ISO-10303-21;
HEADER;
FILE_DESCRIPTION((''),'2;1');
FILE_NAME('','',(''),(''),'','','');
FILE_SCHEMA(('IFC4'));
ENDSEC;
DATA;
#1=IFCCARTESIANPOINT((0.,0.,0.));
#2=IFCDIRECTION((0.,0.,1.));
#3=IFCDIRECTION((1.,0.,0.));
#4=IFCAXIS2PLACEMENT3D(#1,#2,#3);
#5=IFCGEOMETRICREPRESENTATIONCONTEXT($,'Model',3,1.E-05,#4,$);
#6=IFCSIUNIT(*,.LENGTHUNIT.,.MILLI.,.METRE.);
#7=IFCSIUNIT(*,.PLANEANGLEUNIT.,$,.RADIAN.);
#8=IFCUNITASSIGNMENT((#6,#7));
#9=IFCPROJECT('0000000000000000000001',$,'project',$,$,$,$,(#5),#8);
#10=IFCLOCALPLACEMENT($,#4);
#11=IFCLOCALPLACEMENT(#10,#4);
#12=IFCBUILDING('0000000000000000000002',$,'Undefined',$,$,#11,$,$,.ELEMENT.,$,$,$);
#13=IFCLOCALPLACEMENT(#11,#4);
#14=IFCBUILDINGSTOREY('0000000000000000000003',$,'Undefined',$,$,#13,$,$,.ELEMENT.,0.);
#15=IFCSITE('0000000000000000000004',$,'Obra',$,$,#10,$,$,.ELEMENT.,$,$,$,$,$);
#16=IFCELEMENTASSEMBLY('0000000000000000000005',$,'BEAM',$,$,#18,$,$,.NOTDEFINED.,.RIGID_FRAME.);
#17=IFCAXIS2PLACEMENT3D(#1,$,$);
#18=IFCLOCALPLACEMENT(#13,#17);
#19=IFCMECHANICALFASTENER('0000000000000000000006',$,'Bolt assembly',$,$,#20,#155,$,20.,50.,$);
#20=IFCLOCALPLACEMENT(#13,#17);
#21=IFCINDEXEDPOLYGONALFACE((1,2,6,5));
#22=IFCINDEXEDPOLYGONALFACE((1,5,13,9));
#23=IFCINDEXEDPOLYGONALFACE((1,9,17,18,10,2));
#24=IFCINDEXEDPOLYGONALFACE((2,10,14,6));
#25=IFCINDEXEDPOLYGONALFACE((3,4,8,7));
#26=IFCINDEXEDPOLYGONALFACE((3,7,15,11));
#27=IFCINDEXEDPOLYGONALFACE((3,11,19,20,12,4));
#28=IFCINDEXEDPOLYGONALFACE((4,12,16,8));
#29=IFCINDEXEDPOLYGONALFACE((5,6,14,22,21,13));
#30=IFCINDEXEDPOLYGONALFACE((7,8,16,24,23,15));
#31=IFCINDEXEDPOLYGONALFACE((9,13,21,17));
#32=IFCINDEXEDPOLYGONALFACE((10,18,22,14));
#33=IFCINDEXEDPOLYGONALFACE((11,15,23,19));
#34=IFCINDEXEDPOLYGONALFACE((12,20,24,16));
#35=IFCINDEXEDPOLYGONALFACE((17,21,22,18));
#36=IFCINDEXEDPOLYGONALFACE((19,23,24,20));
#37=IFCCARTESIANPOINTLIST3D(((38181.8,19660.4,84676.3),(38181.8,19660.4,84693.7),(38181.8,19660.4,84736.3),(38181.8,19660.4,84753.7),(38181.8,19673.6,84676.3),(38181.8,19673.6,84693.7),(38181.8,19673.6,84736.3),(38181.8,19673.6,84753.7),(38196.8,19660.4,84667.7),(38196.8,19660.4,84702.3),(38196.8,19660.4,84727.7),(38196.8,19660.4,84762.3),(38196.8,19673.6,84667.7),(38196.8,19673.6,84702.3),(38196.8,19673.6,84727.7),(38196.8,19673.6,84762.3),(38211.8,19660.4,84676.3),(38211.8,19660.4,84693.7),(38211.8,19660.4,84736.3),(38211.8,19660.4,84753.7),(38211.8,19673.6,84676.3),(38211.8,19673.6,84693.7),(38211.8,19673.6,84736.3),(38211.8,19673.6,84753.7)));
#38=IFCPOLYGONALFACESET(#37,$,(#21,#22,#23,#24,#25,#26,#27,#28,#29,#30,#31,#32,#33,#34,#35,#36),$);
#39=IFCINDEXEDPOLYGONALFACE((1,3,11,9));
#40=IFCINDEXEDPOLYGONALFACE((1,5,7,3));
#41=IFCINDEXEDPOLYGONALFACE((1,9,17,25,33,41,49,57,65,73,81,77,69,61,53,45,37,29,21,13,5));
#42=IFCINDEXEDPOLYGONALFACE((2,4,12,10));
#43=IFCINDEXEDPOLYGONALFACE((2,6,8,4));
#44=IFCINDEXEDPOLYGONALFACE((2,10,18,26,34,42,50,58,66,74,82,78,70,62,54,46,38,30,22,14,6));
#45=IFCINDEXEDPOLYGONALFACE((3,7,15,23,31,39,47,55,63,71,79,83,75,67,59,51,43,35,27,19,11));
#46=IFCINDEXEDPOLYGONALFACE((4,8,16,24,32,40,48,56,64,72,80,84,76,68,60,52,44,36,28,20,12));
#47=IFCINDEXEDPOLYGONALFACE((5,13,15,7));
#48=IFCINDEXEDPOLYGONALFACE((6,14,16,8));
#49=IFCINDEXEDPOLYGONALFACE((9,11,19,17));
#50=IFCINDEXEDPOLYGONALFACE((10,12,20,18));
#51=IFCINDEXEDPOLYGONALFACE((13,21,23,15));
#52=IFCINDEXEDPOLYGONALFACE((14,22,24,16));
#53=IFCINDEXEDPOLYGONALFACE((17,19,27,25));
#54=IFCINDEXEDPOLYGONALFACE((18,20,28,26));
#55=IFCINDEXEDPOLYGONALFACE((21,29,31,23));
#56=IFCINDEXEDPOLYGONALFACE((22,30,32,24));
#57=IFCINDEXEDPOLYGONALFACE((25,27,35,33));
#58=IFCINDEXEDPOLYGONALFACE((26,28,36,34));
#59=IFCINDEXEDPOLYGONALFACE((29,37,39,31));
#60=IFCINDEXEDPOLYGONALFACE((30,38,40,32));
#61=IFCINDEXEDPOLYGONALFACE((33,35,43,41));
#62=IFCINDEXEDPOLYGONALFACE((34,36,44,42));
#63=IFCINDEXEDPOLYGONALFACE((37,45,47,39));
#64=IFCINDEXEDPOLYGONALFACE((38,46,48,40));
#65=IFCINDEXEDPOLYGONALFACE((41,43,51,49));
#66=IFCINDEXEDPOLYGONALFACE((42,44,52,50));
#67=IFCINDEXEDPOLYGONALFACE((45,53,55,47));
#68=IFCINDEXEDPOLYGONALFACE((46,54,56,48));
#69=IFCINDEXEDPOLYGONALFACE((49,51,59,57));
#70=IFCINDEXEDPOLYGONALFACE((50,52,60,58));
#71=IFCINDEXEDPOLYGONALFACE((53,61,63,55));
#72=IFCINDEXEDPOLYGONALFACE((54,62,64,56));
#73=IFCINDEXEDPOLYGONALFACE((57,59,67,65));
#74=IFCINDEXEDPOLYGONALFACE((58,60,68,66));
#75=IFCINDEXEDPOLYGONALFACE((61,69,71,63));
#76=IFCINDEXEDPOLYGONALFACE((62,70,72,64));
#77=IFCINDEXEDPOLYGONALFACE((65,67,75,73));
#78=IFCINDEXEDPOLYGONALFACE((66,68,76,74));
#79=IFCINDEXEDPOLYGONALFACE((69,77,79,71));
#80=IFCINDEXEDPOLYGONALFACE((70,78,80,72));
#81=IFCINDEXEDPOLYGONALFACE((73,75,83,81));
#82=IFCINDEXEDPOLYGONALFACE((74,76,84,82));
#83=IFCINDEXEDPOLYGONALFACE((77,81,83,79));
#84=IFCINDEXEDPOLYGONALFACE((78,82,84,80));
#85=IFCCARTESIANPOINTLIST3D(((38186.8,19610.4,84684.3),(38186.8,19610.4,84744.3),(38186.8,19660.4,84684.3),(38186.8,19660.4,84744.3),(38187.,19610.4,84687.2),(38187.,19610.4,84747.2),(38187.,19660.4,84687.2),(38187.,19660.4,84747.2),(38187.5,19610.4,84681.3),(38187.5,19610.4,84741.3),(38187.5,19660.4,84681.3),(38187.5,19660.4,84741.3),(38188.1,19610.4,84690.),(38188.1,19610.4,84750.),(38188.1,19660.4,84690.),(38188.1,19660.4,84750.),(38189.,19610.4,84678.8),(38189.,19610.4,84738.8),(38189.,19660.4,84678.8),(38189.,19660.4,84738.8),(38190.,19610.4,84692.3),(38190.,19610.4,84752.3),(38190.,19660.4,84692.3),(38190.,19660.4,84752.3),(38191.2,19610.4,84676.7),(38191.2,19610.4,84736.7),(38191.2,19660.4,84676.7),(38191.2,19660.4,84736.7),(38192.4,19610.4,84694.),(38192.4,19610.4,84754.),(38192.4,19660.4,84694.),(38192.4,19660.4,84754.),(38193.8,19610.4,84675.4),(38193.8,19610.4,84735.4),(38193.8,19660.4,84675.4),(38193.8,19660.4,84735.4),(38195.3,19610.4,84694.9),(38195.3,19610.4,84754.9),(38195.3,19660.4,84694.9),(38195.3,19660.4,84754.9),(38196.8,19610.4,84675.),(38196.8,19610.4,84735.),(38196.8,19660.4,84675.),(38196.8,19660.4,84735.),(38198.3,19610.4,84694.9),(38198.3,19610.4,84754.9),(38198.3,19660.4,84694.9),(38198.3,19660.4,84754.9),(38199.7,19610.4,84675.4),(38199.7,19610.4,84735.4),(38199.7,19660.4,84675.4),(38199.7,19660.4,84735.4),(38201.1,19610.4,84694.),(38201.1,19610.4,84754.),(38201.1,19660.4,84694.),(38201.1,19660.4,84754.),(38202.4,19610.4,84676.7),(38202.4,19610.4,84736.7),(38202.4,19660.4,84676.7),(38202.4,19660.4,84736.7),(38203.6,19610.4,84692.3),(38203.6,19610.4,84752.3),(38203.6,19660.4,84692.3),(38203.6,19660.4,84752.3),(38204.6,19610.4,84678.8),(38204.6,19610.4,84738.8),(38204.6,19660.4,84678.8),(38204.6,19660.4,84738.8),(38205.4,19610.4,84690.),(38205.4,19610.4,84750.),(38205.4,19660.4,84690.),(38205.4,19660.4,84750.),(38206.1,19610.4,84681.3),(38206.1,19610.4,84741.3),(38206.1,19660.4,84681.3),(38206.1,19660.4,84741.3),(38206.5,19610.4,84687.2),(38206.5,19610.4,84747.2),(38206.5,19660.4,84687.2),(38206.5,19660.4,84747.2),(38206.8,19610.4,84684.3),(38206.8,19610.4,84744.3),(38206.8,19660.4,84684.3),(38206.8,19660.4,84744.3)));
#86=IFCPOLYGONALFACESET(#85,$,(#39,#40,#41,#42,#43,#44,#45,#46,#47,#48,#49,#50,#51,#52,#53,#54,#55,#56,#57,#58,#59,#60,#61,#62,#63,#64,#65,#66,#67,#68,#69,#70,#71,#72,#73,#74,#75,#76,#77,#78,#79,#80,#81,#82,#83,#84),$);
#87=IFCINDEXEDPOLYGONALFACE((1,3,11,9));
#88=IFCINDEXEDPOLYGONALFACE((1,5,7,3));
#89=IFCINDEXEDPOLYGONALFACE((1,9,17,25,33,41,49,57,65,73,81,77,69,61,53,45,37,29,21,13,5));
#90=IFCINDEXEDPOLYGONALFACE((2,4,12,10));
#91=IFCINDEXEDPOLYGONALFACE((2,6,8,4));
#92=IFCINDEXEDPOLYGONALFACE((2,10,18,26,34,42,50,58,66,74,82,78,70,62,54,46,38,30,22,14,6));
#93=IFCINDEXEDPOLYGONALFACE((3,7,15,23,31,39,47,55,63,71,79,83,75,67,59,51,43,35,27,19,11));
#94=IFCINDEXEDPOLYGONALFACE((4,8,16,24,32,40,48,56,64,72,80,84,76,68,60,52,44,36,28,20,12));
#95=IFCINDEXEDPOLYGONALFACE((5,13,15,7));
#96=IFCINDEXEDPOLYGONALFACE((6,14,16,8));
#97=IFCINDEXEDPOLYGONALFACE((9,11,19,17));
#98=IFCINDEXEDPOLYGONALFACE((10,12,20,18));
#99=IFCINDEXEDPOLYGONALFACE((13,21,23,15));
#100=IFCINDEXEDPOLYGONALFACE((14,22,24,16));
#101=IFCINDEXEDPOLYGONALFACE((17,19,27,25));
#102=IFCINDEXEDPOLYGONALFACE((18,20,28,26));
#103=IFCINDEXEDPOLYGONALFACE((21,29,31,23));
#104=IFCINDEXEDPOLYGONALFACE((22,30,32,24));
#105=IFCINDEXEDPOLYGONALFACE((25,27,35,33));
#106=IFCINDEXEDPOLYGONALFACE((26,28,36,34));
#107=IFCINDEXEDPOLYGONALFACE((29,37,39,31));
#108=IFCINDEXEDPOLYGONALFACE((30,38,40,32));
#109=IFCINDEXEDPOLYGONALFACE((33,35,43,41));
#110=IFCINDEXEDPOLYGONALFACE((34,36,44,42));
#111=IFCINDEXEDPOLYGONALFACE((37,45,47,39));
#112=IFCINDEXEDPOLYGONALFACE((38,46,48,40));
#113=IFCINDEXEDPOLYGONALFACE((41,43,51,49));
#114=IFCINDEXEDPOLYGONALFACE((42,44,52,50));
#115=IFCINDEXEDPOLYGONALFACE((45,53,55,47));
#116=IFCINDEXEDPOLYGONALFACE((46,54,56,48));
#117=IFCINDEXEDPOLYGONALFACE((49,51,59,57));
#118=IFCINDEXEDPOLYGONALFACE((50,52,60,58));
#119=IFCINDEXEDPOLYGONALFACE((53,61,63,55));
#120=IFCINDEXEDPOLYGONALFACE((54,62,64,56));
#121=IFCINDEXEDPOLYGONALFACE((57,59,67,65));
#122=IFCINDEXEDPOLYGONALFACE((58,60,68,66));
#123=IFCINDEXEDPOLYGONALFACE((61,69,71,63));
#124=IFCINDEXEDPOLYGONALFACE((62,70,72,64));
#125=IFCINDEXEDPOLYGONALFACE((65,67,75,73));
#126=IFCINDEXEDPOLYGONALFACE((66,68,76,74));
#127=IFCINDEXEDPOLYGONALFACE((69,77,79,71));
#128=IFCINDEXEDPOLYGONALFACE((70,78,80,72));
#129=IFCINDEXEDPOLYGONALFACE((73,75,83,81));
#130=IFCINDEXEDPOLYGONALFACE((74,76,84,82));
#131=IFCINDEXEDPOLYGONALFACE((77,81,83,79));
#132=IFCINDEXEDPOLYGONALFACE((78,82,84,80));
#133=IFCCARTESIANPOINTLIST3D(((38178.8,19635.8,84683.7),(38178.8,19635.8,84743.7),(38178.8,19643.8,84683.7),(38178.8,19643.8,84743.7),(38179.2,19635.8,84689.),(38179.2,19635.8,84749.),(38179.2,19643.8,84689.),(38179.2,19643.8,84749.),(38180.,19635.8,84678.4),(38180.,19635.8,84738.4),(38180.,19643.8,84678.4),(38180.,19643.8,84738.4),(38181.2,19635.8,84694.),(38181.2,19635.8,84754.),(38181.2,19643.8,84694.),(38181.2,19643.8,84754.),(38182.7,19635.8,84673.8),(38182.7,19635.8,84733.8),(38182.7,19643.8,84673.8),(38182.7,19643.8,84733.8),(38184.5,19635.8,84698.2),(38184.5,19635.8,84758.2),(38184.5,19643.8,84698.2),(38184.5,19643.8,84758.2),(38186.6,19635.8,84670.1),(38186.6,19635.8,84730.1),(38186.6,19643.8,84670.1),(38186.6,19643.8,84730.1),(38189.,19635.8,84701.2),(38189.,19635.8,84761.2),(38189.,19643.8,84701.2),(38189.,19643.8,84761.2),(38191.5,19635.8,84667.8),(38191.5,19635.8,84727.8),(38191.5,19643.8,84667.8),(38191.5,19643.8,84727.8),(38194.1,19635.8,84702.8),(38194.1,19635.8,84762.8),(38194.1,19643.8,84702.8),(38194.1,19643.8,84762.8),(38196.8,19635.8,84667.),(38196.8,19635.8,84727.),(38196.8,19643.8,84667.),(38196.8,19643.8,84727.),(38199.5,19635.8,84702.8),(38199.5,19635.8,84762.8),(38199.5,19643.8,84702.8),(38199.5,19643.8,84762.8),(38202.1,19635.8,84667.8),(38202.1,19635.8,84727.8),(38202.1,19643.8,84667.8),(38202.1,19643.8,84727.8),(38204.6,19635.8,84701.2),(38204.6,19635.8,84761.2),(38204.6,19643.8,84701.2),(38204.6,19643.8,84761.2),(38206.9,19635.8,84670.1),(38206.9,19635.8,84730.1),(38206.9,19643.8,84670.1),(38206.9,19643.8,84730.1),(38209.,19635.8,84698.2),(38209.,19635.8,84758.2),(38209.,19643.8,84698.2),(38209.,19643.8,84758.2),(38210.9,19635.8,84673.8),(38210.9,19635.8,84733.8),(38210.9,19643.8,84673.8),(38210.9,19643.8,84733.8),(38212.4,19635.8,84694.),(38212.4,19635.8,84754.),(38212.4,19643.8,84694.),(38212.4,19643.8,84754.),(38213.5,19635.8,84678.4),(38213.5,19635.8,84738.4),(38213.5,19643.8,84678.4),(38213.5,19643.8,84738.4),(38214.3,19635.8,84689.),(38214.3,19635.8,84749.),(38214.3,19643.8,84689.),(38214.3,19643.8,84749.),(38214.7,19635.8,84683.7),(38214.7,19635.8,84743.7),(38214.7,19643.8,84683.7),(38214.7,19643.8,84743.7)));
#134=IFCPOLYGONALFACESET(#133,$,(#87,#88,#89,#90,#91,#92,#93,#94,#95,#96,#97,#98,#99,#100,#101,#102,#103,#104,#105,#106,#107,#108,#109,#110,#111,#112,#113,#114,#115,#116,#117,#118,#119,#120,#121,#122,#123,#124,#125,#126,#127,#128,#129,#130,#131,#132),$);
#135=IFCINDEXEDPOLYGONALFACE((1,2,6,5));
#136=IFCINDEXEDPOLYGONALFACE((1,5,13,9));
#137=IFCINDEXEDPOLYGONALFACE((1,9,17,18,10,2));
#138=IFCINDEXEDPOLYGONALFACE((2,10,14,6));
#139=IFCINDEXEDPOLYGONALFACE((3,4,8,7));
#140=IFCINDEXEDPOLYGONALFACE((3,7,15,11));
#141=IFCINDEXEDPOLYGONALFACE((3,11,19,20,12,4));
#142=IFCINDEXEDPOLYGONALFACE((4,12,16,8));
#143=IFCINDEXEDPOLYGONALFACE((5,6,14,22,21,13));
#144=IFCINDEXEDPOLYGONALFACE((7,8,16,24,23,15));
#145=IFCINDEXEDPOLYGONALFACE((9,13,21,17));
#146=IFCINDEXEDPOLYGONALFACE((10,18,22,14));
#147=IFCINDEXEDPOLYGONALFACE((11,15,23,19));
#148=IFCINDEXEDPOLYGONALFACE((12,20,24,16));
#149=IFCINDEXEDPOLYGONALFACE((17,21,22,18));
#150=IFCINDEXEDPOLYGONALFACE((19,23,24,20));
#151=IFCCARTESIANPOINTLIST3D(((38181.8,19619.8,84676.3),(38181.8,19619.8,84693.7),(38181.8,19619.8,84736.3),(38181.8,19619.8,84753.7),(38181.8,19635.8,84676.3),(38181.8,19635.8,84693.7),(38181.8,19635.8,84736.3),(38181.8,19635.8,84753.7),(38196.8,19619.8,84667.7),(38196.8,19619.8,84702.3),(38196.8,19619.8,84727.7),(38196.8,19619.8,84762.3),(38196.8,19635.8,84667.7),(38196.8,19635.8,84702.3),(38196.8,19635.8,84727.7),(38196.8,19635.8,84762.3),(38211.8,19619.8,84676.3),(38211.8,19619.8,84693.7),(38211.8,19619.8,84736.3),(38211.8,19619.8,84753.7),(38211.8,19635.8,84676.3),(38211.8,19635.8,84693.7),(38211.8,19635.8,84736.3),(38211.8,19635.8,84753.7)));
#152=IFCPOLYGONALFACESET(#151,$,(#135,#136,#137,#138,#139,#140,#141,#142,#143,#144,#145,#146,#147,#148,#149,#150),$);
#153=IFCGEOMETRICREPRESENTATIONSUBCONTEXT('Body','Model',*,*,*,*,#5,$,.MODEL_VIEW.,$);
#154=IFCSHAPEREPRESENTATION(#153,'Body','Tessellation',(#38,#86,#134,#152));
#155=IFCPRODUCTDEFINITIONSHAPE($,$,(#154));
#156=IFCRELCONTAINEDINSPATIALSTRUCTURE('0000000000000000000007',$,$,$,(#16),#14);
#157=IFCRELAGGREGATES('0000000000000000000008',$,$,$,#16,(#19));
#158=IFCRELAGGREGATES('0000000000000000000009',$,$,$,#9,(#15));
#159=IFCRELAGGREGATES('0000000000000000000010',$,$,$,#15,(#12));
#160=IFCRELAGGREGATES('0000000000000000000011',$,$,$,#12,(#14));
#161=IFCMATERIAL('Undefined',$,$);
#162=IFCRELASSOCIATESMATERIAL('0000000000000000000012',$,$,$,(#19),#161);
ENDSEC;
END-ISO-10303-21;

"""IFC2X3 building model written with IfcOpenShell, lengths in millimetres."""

from ifc_helpers import new_model, si_unit, frame, origin_with_axes, origin_2d_with_axis, place, context, subcontext, project, spatial, polyline, circle, outline, extrude, source, transform, mapped, material, element, aggregate, save


model = new_model("IFC2X3")

# Units and contexts
model_context = context("Model", 3, precision=1e-05, world=origin_with_axes())
body_context = subcontext(model_context, "Body", "Model", "MODEL_VIEW")
ifc_project = project(units=[si_unit("LENGTHUNIT", "METRE", prefix="MILLI"), si_unit("PLANEANGLEUNIT", "RADIAN")], contexts=[model_context])

# Site, building, storey
site_placement = place(None, origin_with_axes())
site = spatial("IfcSite", under=ifc_project, at=site_placement, Name="Obra", CompositionType="ELEMENT")
building_placement = place(site_placement, origin_with_axes())
building = spatial("IfcBuilding", under=site, at=building_placement, Name="Undefined", CompositionType="ELEMENT")
storey_placement = place(building_placement, origin_with_axes())
storey = spatial("IfcBuildingStorey", under=building, at=storey_placement, Name="Undefined", CompositionType="ELEMENT", Elevation=0.0)

# Shared definitions
ifc_material_1 = material(Name="Undefined")

# Element assembly, mechanical fastener
assembly_1_placement = place(storey_placement, origin_with_axes())
assembly_1 = element("IfcElementAssembly", 1, at=assembly_1_placement, inside=storey, Name="BEAM", AssemblyPlace="NOTDEFINED", PredefinedType="RIGID_FRAME")
shared_shape_1 = source(origin_with_axes(), body_context, "Body", "SweptSolid", [
    extrude(outline(polyline([(17.3, 0.0), (8.7, 15.0), (-8.7, 15.0), (-17.3, 0.0), (-8.7, -15.0), (8.7, -15.0), (17.3, 0.0)])), frame((0.0, -26.5, 0.0), z_axis=(0.0, 1.0, 0.0), x_axis=(1.0, 0.0, 0.0)), (0.0, 0.0, 1.0), 13.2),
    extrude(circle(Radius=10.0, at=origin_2d_with_axis()), frame((0.0, -13.3, 0.0), z_axis=(0.0, 1.0, 0.0), x_axis=(1.0, 0.0, 0.0)), (0.0, 0.0, 1.0), 50.0),
    extrude(circle(Radius=18.0, at=origin_2d_with_axis()), frame((0.0, 3.3, 0.0), z_axis=(0.0, 1.0, 0.0), x_axis=(1.0, 0.0, 0.0)), (0.0, 0.0, 1.0), 8.0),
    extrude(outline(polyline([(17.3, 0.0), (8.7, 15.0), (-8.7, 15.0), (-17.3, 0.0), (-8.7, -15.0), (8.7, -15.0), (17.3, 0.0)])), frame((0.0, 11.3, 0.0), z_axis=(0.0, 1.0, 0.0), x_axis=(1.0, 0.0, 0.0)), (0.0, 0.0, 1.0), 16.0),
])
mechanical_fastener_1_placement = place(assembly_1_placement, frame((38236.8, 19647.1, 84850.0), z_axis=(-1.0, 0.0, 0.0), x_axis=(0.0, 0.0, -1.0)))
mechanical_fastener_1 = element("IfcMechanicalFastener", 2, at=mechanical_fastener_1_placement, material=ifc_material_1, Name="Bolt assembly", NominalDiameter=20.0, NominalLength=50.0, context=body_context, shape_type="MappedRepresentation", body=[
    mapped(shared_shape_1, transform((105.0, 0.0, 40.0))),
    mapped(shared_shape_1, transform((165.0, 0.0, 40.0))),
])
aggregate(assembly_1, [mechanical_fastener_1])

save(model, "model.ifc")
